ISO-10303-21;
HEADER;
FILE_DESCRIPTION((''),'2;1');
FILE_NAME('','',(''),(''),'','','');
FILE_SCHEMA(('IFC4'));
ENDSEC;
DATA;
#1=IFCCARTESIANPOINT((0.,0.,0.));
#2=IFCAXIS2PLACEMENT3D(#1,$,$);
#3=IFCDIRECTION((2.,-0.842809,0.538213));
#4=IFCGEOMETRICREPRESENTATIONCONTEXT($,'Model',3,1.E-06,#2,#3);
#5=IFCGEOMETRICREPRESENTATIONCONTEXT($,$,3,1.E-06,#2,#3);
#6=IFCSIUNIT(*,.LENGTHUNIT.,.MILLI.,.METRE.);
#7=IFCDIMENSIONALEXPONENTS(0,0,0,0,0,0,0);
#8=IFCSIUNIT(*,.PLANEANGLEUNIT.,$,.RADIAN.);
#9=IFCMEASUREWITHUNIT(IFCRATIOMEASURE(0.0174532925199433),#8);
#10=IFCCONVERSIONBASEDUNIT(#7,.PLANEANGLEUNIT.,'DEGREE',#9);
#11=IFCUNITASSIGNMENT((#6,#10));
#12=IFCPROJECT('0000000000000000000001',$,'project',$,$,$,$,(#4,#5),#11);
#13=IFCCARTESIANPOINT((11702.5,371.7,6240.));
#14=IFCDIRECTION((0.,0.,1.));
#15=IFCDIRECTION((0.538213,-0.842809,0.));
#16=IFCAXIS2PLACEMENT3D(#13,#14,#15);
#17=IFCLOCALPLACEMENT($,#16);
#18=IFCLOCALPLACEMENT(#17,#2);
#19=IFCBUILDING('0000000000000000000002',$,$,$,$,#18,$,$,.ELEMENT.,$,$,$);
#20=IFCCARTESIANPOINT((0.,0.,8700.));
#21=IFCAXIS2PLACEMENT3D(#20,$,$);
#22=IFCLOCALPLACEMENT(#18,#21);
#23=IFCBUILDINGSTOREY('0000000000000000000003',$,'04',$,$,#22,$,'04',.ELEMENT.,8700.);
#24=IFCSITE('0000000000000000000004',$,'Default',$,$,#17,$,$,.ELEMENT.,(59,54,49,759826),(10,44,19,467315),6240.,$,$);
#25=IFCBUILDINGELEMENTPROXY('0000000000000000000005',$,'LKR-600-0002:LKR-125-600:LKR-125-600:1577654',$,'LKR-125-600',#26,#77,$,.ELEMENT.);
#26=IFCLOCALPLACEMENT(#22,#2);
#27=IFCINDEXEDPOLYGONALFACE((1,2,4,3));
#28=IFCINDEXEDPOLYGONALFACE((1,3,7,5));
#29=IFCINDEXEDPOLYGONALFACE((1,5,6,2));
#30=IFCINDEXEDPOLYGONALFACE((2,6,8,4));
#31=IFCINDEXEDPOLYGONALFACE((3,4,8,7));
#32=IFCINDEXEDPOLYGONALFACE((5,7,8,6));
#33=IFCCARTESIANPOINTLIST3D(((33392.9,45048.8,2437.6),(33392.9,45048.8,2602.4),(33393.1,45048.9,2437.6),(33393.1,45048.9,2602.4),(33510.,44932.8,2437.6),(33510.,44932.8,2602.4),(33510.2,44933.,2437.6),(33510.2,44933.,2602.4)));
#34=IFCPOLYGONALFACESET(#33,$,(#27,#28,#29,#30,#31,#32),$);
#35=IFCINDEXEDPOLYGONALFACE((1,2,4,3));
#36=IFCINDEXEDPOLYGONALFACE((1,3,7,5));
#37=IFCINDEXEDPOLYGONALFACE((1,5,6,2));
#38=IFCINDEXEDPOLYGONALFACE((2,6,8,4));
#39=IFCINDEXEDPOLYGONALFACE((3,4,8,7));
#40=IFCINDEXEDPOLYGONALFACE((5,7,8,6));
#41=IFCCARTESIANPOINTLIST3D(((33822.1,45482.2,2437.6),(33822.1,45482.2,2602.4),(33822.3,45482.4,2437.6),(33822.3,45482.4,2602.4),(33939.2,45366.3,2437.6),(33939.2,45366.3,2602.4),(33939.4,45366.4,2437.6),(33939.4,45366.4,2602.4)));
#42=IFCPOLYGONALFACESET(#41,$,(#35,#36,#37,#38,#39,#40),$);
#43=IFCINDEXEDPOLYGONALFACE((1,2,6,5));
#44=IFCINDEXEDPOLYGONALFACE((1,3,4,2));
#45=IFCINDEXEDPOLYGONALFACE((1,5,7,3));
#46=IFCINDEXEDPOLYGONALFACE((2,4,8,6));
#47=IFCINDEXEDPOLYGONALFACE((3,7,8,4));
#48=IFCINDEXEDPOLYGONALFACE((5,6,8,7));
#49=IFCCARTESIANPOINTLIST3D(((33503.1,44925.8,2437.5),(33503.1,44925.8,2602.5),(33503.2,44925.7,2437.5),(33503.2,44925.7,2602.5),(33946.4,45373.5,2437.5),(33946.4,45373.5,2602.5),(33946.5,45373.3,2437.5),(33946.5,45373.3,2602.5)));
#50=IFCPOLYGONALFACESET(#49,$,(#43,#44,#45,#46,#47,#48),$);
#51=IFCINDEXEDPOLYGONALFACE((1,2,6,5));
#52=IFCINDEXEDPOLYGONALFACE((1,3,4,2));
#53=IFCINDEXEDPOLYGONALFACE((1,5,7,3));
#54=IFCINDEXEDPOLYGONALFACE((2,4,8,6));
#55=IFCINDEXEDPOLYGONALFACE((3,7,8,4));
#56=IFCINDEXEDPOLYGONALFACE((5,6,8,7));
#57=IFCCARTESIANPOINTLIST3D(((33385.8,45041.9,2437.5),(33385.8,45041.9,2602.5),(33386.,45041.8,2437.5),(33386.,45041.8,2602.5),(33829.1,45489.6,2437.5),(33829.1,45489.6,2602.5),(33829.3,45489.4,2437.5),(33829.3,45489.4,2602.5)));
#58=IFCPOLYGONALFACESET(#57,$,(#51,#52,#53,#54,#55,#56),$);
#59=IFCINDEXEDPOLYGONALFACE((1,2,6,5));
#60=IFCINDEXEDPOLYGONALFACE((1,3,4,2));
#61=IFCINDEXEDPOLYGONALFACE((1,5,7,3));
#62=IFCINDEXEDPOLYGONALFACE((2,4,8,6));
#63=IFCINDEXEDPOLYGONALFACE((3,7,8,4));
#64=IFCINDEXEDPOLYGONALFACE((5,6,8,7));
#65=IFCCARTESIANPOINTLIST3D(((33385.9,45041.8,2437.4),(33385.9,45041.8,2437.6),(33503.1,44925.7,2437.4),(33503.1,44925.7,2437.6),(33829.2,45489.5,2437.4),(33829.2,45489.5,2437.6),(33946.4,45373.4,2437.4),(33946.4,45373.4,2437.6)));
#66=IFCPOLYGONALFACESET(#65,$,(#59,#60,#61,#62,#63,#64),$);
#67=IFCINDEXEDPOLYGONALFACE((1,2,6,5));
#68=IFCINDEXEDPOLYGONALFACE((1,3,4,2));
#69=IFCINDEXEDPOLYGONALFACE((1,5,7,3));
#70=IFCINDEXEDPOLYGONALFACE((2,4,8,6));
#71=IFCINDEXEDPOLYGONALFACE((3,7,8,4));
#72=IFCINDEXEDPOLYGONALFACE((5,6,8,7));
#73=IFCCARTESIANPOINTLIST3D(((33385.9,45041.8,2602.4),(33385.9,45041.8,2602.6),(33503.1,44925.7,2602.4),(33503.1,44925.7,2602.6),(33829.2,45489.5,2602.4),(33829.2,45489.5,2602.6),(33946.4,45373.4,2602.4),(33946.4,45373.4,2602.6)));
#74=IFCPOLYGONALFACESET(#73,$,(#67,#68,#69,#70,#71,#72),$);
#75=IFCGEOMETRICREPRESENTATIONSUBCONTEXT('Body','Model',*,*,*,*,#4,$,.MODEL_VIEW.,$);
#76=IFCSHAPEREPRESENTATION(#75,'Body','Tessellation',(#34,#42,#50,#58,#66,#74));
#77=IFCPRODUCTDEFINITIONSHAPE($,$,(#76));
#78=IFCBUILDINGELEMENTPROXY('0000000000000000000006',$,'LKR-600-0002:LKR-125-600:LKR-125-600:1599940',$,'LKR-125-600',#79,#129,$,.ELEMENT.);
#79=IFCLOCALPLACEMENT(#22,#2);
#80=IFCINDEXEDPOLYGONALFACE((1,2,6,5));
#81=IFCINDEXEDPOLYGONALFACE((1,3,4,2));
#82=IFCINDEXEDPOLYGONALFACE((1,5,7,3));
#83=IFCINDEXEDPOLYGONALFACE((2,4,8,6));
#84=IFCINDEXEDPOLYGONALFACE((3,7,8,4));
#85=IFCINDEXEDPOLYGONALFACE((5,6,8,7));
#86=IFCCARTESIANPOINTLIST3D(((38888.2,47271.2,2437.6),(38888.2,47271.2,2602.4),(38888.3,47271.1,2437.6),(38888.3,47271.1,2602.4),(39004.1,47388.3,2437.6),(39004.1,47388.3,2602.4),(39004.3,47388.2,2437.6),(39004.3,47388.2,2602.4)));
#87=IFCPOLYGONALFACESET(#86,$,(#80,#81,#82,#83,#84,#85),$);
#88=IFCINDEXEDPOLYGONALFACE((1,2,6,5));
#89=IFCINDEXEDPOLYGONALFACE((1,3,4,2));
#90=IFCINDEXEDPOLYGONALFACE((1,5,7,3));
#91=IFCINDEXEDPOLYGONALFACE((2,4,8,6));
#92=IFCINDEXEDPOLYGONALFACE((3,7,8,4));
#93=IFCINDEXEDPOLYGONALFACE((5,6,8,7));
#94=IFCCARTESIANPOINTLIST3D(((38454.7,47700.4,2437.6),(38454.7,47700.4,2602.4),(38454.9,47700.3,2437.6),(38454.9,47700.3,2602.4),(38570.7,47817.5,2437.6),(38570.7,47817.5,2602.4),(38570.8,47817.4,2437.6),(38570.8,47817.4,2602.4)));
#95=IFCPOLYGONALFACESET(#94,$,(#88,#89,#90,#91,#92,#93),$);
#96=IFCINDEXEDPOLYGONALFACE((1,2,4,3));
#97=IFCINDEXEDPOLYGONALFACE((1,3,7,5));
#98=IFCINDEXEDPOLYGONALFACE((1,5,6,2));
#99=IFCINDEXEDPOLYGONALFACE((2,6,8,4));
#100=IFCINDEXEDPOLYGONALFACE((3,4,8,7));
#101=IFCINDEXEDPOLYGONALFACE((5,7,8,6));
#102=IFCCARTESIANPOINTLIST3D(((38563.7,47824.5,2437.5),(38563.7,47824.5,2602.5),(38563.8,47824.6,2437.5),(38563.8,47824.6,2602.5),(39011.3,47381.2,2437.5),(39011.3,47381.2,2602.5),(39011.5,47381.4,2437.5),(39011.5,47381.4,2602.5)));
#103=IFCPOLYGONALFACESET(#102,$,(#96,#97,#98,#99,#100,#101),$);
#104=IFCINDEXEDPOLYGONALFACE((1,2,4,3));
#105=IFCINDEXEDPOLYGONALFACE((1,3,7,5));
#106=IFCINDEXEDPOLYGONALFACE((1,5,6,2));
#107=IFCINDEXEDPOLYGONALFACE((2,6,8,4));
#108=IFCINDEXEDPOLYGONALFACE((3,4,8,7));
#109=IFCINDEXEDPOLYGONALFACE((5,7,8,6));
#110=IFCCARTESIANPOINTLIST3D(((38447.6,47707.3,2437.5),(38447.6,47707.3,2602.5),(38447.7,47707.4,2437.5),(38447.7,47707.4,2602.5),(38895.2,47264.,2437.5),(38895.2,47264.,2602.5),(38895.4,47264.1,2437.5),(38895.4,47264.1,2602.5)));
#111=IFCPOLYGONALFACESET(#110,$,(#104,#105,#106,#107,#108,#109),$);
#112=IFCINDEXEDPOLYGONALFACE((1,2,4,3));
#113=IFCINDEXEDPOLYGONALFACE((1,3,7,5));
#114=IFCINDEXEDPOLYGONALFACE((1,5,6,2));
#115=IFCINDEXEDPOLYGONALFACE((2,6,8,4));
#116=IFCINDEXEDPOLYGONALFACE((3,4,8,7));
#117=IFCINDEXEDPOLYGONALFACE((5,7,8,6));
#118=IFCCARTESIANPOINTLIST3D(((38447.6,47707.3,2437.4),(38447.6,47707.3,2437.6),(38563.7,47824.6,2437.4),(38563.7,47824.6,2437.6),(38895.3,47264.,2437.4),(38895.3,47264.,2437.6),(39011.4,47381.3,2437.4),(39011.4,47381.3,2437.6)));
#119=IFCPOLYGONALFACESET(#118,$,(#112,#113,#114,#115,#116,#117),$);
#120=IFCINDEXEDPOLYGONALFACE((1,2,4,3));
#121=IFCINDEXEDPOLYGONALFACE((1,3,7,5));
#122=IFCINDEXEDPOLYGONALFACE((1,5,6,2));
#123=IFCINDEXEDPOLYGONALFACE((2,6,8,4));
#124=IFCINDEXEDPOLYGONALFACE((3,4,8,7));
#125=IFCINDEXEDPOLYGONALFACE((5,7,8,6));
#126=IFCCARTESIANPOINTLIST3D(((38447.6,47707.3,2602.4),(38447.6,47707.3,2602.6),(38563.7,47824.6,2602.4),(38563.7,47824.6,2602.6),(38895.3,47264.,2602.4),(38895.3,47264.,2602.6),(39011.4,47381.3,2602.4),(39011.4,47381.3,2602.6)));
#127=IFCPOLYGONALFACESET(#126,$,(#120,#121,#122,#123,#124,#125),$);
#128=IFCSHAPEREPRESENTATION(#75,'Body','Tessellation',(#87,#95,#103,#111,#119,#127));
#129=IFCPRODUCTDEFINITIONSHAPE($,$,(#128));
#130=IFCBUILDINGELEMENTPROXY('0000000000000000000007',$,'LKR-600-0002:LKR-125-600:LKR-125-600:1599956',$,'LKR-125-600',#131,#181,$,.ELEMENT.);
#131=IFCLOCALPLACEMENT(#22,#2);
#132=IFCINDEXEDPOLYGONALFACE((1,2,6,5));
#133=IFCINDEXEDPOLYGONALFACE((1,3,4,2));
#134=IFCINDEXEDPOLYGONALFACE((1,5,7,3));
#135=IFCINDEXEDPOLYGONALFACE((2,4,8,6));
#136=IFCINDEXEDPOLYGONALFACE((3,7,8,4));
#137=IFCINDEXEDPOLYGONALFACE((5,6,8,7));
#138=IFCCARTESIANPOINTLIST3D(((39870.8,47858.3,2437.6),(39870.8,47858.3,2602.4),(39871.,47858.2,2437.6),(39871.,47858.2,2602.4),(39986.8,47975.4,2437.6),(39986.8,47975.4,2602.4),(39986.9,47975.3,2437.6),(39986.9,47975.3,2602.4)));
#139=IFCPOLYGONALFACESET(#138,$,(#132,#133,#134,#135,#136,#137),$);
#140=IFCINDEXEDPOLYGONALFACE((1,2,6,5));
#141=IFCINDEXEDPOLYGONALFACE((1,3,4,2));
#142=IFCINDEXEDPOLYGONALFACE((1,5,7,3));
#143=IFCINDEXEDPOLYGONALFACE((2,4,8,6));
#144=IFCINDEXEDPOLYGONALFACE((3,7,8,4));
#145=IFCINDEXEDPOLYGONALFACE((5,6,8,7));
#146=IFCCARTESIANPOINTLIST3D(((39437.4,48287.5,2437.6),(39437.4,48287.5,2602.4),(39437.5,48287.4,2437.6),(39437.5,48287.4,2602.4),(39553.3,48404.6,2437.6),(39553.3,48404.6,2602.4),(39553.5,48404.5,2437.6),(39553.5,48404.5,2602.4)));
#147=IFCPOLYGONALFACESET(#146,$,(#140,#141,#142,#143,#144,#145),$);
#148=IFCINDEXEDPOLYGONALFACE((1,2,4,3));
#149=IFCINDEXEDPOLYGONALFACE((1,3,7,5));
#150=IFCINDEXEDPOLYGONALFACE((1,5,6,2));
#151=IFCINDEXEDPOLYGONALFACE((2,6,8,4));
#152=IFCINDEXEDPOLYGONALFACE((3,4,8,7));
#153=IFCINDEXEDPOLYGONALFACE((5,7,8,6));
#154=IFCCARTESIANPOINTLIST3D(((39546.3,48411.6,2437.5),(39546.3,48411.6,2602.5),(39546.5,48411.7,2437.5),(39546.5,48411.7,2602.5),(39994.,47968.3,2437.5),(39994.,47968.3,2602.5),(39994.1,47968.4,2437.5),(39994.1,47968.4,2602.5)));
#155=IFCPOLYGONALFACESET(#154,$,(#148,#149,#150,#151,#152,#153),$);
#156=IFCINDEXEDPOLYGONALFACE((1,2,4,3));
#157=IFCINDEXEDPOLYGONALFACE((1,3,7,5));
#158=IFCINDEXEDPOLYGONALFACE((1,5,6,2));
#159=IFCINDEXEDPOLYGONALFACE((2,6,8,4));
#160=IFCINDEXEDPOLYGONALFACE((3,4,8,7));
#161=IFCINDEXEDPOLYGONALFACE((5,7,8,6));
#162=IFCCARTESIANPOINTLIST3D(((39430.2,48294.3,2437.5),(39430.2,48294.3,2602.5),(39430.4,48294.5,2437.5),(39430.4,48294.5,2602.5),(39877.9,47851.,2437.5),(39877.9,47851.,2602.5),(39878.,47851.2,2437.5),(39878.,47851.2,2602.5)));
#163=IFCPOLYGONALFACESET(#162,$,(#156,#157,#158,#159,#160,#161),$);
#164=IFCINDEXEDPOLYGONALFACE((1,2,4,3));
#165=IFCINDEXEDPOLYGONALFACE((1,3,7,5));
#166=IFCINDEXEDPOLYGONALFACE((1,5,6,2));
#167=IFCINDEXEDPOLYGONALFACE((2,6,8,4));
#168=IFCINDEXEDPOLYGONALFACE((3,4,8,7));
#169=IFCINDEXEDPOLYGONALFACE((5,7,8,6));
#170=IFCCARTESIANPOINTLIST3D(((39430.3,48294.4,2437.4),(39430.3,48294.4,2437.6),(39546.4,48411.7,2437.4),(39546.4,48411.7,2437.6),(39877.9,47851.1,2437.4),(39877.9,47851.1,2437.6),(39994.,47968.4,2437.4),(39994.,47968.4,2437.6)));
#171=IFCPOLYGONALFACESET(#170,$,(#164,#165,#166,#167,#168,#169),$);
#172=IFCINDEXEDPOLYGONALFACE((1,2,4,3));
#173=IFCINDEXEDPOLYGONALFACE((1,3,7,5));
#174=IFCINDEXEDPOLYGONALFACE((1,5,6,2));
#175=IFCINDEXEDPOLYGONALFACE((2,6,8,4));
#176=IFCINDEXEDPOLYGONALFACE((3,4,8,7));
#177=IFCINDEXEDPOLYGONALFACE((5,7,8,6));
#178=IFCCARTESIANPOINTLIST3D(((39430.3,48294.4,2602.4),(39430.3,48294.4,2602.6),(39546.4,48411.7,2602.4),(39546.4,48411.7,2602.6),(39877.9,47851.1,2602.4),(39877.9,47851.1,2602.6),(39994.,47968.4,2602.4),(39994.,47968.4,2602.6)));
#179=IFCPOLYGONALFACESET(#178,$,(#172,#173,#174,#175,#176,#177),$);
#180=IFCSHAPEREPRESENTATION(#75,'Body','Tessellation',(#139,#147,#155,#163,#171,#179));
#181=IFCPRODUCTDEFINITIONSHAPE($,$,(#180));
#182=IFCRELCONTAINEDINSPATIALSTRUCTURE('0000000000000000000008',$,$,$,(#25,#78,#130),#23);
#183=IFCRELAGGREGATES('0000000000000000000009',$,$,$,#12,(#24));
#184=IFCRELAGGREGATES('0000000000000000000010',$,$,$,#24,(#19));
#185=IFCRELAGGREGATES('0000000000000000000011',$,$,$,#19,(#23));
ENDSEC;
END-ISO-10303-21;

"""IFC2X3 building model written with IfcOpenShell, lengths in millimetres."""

from ifc_helpers import new_model, entity, si_unit, converted_unit, direction, frame, frame_2d, origin, place, context, subcontext, project, spatial, rectangle, extrude, source, transform, mapped, element, save


model = new_model("IFC2X3")

# Units and contexts
model_context = context("Model", 3, precision=1e-06, world=origin(), true_north=direction((2.0, -0.842809, 0.538213)))
context_of_model = context(None, 3, precision=1e-06, world=origin(), true_north=direction((2.0, -0.842809, 0.538213)))
body_context = subcontext(model_context, "Body", "Model", "MODEL_VIEW")
ifc_project = project(units=[si_unit("LENGTHUNIT", "METRE", prefix="MILLI"), converted_unit("PLANEANGLEUNIT", "DEGREE", entity("IfcRatioMeasure", 0.0174532925199433), si_unit("PLANEANGLEUNIT", "RADIAN"), dimensions=[0, 0, 0, 0, 0, 0, 0])], contexts=[model_context, context_of_model])

# Site, building, storey
site_placement = place(None, frame((11702.5, 371.7, 6240.0), z_axis=(0.0, 0.0, 1.0), x_axis=(0.538213, -0.842809, 0.0)))
site = spatial("IfcSite", under=ifc_project, at=site_placement, Name="Default", CompositionType="ELEMENT", RefLatitude=(59, 54, 49, 759826), RefLongitude=(10, 44, 19, 467315), RefElevation=6240.0)
building_placement = place(site_placement, origin())
building = spatial("IfcBuilding", under=site, at=building_placement, CompositionType="ELEMENT")
storey_placement = place(building_placement, frame((0.0, 0.0, 8700.0)))
storey = spatial("IfcBuildingStorey", under=building, at=storey_placement, Name="04", LongName="04", CompositionType="ELEMENT", Elevation=8700.0)

# Building element proxies
shared_shape_1 = source(origin(), body_context, "Body", "SweptSolid", [
    extrude(rectangle(XDim=0.2, YDim=164.8, at=frame_2d((0.0, 0.0), x_axis=(1.0, 0.0))), frame((305.0, 0.0, -82.4)), (0.0, 0.0, 1.0), 164.8),
    extrude(rectangle(XDim=0.2, YDim=164.8, at=frame_2d((0.0, 0.0), x_axis=(1.0, 0.0))), frame((-305.0, 0.0, -82.4)), (0.0, 0.0, 1.0), 164.8),
    extrude(rectangle(XDim=0.2, YDim=630.0, at=frame_2d((0.0, 0.0), x_axis=(1.0, 0.0))), frame((0.0, 82.5, -82.5), z_axis=(0.0, 0.0, 1.0), x_axis=(0.0, 1.0, 0.0)), (0.0, 0.0, 1.0), 165.0),
    extrude(rectangle(XDim=0.2, YDim=630.0, at=frame_2d((0.0, 0.0), x_axis=(1.0, 0.0))), frame((0.0, -82.5, -82.5), z_axis=(0.0, 0.0, 1.0), x_axis=(0.0, 1.0, 0.0)), (0.0, 0.0, 1.0), 165.0),
    extrude(rectangle(XDim=165.0, YDim=630.0, at=frame_2d((0.0, 0.0), x_axis=(1.0, 0.0))), frame((0.0, 0.0, -82.6), z_axis=(0.0, 0.0, 1.0), x_axis=(0.0, -1.0, 0.0)), (0.0, 0.0, 1.0), 0.2),
    extrude(rectangle(XDim=165.0, YDim=630.0, at=frame_2d((0.0, 0.0), x_axis=(1.0, 0.0))), frame((0.0, 0.0, 82.4), z_axis=(0.0, 0.0, 1.0), x_axis=(0.0, -1.0, 0.0)), (0.0, 0.0, 1.0), 0.2),
])
for number, where, z_axis, x_axis, name in (
    (1, (33666.2, 45207.6, 11220.0), (0.0, 0.0, 1.0), (-0.703643, -0.710554, 0.0), "LKR-600-0002:LKR-125-600:LKR-125-600:1577654"),
    (2, (38729.5, 47544.3, 11220.0), (0.0, 0.0, 1.0), (0.710554, -0.703643, 0.0), "LKR-600-0002:LKR-125-600:LKR-125-600:1599940"),
    (3, (39712.2, 48131.4, 11220.0), (0.0, 0.0, 1.0), (0.710554, -0.703643, 0.0), "LKR-600-0002:LKR-125-600:LKR-125-600:1599956"),
):
    element("IfcBuildingElementProxy", number, at=place(building_placement, frame(where, z_axis=z_axis, x_axis=x_axis)), inside=storey, Name=name, ObjectType="LKR-125-600", CompositionType="ELEMENT", context=body_context, shape_type="MappedRepresentation", body=[
        mapped(shared_shape_1, transform((0.0, 0.0, 0.0), scale=1.0)),
    ])

save(model, "model.ifc")
